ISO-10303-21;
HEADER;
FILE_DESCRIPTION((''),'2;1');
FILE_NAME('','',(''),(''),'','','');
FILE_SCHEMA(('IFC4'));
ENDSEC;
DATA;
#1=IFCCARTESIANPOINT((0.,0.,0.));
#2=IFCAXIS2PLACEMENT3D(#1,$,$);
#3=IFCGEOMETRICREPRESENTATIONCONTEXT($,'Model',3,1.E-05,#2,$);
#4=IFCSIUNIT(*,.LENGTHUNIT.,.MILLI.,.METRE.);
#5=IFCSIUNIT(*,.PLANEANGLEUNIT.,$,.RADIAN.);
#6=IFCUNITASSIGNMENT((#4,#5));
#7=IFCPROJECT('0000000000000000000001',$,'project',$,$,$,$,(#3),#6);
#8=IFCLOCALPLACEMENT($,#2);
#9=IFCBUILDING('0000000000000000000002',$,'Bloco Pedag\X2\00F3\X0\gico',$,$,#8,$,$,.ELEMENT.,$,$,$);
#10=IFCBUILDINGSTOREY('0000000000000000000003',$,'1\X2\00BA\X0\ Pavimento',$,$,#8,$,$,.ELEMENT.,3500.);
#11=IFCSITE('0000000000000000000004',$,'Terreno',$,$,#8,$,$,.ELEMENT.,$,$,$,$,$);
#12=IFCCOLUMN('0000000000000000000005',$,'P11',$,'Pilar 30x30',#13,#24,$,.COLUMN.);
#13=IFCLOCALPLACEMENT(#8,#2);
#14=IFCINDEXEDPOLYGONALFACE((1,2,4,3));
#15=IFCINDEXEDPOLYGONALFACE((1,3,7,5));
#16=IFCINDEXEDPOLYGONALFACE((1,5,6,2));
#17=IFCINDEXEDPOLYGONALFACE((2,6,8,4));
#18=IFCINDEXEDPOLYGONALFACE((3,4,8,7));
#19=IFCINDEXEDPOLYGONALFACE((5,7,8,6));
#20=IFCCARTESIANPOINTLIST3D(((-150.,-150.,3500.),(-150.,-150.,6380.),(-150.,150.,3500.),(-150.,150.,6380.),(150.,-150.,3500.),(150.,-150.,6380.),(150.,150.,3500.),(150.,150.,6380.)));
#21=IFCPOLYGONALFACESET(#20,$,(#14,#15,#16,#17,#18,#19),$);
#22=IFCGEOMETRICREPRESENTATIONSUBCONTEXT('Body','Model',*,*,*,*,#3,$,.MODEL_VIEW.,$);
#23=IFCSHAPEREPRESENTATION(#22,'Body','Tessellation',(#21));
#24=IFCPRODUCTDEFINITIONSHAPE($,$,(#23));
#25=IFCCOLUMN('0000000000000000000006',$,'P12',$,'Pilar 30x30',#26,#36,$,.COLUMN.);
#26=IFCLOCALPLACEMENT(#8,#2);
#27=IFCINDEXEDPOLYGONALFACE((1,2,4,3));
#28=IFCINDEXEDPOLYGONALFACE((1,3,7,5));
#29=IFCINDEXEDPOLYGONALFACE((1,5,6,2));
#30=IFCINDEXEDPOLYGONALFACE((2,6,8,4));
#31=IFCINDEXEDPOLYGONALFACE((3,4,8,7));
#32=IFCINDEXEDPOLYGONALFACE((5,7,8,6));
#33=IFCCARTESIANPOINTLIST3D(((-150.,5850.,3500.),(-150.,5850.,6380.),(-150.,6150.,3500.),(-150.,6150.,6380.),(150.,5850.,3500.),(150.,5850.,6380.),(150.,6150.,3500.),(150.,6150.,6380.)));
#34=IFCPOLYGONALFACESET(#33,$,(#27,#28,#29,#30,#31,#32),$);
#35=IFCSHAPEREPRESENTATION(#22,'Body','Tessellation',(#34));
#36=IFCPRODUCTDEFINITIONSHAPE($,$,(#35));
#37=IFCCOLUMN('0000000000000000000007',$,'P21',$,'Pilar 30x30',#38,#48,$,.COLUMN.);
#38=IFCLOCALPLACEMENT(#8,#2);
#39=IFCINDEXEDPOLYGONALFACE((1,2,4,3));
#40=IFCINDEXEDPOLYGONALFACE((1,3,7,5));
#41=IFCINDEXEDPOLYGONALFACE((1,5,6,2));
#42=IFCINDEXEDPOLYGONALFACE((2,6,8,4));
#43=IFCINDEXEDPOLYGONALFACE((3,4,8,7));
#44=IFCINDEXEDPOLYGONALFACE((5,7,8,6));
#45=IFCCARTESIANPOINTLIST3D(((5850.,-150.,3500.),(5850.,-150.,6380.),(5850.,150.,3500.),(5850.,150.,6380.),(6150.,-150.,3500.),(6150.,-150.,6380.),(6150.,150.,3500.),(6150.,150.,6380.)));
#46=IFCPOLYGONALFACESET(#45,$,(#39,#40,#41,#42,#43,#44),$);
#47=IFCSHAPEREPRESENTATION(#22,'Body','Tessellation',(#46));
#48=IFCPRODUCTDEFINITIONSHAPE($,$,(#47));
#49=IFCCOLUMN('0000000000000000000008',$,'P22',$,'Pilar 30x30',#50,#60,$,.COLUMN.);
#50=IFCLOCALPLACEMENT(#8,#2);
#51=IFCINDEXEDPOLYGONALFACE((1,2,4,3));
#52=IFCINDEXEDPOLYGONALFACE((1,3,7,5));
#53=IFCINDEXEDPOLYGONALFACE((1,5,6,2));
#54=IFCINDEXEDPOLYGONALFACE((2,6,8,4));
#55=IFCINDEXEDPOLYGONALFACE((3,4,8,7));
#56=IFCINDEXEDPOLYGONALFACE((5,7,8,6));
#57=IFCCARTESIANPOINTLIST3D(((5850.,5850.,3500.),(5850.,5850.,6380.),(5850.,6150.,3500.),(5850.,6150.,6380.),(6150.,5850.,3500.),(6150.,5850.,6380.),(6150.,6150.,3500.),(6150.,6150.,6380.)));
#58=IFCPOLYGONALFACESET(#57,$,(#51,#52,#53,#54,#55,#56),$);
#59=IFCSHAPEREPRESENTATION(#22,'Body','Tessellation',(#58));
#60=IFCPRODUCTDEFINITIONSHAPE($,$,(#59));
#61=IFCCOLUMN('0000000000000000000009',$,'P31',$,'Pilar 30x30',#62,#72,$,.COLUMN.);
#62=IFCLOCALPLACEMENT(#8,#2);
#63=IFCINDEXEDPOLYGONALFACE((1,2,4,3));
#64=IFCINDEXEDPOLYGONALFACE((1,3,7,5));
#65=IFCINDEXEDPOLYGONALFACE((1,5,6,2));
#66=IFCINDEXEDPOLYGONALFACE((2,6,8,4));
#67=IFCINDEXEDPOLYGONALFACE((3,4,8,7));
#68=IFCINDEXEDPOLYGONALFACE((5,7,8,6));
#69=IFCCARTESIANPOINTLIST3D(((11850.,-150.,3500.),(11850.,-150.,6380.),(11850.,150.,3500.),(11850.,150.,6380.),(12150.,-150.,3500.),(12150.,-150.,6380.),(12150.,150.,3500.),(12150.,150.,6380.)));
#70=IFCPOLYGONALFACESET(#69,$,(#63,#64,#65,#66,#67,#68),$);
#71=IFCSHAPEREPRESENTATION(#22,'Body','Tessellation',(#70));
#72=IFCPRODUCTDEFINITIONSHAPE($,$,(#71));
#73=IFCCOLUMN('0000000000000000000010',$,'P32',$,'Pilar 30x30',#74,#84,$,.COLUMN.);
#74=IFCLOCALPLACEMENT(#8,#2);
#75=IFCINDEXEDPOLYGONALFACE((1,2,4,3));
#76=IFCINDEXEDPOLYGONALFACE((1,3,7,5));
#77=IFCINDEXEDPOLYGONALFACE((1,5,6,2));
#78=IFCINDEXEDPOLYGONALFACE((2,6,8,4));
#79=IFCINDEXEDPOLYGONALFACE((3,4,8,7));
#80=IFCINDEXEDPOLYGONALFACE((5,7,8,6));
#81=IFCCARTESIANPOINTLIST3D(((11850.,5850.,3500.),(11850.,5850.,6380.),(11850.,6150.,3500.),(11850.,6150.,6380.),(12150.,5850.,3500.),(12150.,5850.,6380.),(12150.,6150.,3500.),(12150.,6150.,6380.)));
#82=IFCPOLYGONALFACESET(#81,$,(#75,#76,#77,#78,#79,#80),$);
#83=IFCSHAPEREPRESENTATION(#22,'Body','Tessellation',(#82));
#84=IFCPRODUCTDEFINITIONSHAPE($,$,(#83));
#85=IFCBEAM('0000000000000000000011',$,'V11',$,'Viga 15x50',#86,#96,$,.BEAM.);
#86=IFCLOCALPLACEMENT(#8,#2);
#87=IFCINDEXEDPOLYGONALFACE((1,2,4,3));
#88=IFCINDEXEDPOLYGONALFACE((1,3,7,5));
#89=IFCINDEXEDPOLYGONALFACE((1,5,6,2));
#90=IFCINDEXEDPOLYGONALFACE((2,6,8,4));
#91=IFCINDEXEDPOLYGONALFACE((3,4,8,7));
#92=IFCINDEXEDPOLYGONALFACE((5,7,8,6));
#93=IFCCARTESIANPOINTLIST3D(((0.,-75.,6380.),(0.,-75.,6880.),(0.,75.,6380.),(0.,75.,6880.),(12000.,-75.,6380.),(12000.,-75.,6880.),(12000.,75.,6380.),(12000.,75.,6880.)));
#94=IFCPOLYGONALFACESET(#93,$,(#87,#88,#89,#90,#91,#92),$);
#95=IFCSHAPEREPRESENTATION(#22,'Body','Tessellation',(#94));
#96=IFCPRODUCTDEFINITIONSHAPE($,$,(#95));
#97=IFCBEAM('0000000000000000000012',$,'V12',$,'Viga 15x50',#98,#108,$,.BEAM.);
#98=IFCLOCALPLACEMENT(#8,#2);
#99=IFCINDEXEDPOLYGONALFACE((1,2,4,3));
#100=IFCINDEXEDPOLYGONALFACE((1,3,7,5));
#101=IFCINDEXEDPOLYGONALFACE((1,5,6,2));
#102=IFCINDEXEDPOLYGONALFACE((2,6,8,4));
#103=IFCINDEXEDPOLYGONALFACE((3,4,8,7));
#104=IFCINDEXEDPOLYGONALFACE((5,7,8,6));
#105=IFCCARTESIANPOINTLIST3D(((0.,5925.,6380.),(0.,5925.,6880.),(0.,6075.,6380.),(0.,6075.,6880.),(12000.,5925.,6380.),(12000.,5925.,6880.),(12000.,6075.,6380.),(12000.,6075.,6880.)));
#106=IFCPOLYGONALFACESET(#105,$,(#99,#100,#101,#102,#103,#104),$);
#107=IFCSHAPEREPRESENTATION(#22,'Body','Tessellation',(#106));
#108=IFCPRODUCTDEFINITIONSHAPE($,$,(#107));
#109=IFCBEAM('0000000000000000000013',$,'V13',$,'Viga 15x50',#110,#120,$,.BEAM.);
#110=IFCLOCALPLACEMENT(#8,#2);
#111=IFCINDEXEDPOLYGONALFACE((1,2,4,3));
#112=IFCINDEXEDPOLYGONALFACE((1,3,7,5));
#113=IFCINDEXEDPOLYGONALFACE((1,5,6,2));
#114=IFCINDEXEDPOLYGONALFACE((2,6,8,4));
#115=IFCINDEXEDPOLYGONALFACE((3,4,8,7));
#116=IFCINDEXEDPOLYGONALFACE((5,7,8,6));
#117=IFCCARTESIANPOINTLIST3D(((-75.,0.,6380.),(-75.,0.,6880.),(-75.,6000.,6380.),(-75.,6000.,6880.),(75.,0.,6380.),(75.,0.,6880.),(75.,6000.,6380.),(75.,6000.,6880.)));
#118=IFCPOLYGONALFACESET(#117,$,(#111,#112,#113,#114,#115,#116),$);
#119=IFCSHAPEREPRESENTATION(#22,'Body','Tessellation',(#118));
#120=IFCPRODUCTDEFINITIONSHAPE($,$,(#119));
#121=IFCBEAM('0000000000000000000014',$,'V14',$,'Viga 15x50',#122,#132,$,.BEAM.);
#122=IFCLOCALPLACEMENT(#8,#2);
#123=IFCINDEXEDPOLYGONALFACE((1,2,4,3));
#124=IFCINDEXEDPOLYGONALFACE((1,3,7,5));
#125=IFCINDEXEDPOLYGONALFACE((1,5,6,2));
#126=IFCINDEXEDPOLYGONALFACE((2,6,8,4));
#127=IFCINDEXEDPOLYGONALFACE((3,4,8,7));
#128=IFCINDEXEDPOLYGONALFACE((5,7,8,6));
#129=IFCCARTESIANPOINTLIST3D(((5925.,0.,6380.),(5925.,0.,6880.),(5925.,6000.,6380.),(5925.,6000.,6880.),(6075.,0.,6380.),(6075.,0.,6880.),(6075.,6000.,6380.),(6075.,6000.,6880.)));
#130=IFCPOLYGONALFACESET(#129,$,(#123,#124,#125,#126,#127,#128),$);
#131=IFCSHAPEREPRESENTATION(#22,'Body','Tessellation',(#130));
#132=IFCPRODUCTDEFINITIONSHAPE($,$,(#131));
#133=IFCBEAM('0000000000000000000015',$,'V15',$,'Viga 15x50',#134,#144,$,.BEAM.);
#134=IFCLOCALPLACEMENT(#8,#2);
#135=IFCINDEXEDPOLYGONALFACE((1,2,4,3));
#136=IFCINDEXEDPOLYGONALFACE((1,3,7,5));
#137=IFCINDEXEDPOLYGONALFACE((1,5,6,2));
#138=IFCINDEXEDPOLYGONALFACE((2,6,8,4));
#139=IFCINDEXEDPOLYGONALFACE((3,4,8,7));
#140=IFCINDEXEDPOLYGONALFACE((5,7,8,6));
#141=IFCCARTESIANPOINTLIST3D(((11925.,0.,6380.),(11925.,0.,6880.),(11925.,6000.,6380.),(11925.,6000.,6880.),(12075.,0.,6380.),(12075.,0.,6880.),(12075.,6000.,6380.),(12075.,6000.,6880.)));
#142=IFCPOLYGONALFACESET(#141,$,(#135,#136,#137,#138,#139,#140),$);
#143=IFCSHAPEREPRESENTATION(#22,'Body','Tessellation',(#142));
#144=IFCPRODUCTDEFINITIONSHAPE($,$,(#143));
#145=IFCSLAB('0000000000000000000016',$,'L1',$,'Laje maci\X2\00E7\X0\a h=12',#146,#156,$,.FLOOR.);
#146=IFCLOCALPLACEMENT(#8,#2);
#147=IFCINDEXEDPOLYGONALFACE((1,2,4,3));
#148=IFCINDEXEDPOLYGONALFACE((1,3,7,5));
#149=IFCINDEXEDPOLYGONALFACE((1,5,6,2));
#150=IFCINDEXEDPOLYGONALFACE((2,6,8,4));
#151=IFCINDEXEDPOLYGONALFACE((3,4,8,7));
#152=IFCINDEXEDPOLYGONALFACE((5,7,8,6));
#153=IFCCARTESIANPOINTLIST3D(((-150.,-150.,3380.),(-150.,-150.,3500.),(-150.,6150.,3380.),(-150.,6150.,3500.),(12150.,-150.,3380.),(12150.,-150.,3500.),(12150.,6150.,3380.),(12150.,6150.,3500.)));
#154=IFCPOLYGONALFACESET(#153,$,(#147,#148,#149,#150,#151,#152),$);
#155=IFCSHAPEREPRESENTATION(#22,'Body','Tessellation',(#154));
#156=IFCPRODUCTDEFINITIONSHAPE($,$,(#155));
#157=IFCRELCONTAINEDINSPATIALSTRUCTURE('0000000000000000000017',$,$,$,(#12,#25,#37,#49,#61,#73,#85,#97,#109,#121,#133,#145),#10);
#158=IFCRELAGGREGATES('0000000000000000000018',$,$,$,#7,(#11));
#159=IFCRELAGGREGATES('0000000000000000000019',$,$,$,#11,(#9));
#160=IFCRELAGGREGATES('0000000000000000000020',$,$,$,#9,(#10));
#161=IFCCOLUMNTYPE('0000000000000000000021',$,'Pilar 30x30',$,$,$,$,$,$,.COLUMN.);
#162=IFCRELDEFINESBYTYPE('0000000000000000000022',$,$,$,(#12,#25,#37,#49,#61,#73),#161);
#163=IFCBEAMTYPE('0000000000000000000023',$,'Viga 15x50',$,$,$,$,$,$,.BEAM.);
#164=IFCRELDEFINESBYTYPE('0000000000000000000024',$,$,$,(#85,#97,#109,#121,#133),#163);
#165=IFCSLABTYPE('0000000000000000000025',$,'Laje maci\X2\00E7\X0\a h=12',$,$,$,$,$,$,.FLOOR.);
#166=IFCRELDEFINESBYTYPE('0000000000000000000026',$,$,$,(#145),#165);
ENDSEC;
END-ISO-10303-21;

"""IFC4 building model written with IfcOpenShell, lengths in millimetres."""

from ifc_helpers import new_model, si_unit, frame, origin, origin_2d, place, context, subcontext, project, spatial, rectangle, extrude, type_object, element, save


model = new_model("IFC4")

# Units and contexts
model_context = context("Model", 3, precision=1e-05, world=origin())
body_context = subcontext(model_context, "Body", "Model", "MODEL_VIEW")
ifc_project = project(units=[si_unit("LENGTHUNIT", "METRE", prefix="MILLI"), si_unit("PLANEANGLEUNIT", "RADIAN")], contexts=[model_context])

# Site, building, storey
placement = place(None, origin())
site = spatial("IfcSite", under=ifc_project, at=placement, Name="Terreno", CompositionType="ELEMENT")
building = spatial("IfcBuilding", under=site, at=placement, Name="Bloco Pedagógico", CompositionType="ELEMENT")
storey = spatial("IfcBuildingStorey", under=building, at=placement, Name="1º Pavimento", CompositionType="ELEMENT", Elevation=3500.0)

# Columns
column_type = type_object("IfcColumnType", Name="Pilar 30x30", PredefinedType="COLUMN")
for number, where, z_axis, x_axis, name in (
    (1, (0.0, 0.0, 3500.0), (0.0, 0.0, 1.0), (1.0, 0.0, 0.0), "P11"),
    (2, (0.0, 6000.0, 3500.0), (0.0, 0.0, 1.0), (1.0, 0.0, 0.0), "P12"),
    (3, (6000.0, 0.0, 3500.0), (0.0, 0.0, 1.0), (1.0, 0.0, 0.0), "P21"),
    (4, (6000.0, 6000.0, 3500.0), (0.0, 0.0, 1.0), (1.0, 0.0, 0.0), "P22"),
    (5, (12000.0, 0.0, 3500.0), (0.0, 0.0, 1.0), (1.0, 0.0, 0.0), "P31"),
    (6, (12000.0, 6000.0, 3500.0), (0.0, 0.0, 1.0), (1.0, 0.0, 0.0), "P32"),
):
    element("IfcColumn", number, at=place(None, frame(where, z_axis=z_axis, x_axis=x_axis)), inside=storey, type_object=column_type, Name=name, ObjectType="Pilar 30x30", PredefinedType="COLUMN", context=body_context, shape_type="SweptSolid", body=[
        extrude(rectangle(XDim=300.0, YDim=300.0, at=origin_2d()), None, (0.0, 0.0, 1.0), 2880.0),
    ])

# Beams
beam_type = type_object("IfcBeamType", Name="Viga 15x50", PredefinedType="BEAM")
for number, where, z_axis, x_axis, name in (
    (7, (0.0, 0.0, 6630.0), (1.0, 0.0, 0.0), (0.0, 1.0, 0.0), "V11"),
    (8, (0.0, 6000.0, 6630.0), (1.0, 0.0, 0.0), (0.0, 1.0, 0.0), "V12"),
):
    element("IfcBeam", number, at=place(None, frame(where, z_axis=z_axis, x_axis=x_axis)), inside=storey, type_object=beam_type, Name=name, ObjectType="Viga 15x50", PredefinedType="BEAM", context=body_context, shape_type="SweptSolid", body=[
        extrude(rectangle(XDim=150.0, YDim=500.0, at=origin_2d()), None, (0.0, 0.0, 1.0), 12000.0),
    ])
for number, where, z_axis, x_axis, name in (
    (9, (0.0, 0.0, 6630.0), (0.0, 1.0, 0.0), (1.0, 0.0, 0.0), "V13"),
    (10, (6000.0, 0.0, 6630.0), (0.0, 1.0, 0.0), (1.0, 0.0, 0.0), "V14"),
    (11, (12000.0, 0.0, 6630.0), (0.0, 1.0, 0.0), (1.0, 0.0, 0.0), "V15"),
):
    element("IfcBeam", number, at=place(None, frame(where, z_axis=z_axis, x_axis=x_axis)), inside=storey, type_object=beam_type, Name=name, ObjectType="Viga 15x50", PredefinedType="BEAM", context=body_context, shape_type="SweptSolid", body=[
        extrude(rectangle(XDim=150.0, YDim=500.0, at=origin_2d()), None, (0.0, 0.0, 1.0), 6000.0),
    ])

# Slab
slab_type = type_object("IfcSlabType", Name="Laje maciça h=12", PredefinedType="FLOOR")
slab_placement = place(None, frame((6000.0, 3000.0, 3380.0), z_axis=(0.0, 0.0, 1.0), x_axis=(1.0, 0.0, 0.0)))
element("IfcSlab", 12, at=slab_placement, inside=storey, type_object=slab_type, Name="L1", ObjectType="Laje maciça h=12", PredefinedType="FLOOR", context=body_context, shape_type="SweptSolid", body=[
    extrude(rectangle(XDim=12300.0, YDim=6300.0, at=origin_2d()), None, (0.0, 0.0, 1.0), 120.0),
])

save(model, "model.ifc")
